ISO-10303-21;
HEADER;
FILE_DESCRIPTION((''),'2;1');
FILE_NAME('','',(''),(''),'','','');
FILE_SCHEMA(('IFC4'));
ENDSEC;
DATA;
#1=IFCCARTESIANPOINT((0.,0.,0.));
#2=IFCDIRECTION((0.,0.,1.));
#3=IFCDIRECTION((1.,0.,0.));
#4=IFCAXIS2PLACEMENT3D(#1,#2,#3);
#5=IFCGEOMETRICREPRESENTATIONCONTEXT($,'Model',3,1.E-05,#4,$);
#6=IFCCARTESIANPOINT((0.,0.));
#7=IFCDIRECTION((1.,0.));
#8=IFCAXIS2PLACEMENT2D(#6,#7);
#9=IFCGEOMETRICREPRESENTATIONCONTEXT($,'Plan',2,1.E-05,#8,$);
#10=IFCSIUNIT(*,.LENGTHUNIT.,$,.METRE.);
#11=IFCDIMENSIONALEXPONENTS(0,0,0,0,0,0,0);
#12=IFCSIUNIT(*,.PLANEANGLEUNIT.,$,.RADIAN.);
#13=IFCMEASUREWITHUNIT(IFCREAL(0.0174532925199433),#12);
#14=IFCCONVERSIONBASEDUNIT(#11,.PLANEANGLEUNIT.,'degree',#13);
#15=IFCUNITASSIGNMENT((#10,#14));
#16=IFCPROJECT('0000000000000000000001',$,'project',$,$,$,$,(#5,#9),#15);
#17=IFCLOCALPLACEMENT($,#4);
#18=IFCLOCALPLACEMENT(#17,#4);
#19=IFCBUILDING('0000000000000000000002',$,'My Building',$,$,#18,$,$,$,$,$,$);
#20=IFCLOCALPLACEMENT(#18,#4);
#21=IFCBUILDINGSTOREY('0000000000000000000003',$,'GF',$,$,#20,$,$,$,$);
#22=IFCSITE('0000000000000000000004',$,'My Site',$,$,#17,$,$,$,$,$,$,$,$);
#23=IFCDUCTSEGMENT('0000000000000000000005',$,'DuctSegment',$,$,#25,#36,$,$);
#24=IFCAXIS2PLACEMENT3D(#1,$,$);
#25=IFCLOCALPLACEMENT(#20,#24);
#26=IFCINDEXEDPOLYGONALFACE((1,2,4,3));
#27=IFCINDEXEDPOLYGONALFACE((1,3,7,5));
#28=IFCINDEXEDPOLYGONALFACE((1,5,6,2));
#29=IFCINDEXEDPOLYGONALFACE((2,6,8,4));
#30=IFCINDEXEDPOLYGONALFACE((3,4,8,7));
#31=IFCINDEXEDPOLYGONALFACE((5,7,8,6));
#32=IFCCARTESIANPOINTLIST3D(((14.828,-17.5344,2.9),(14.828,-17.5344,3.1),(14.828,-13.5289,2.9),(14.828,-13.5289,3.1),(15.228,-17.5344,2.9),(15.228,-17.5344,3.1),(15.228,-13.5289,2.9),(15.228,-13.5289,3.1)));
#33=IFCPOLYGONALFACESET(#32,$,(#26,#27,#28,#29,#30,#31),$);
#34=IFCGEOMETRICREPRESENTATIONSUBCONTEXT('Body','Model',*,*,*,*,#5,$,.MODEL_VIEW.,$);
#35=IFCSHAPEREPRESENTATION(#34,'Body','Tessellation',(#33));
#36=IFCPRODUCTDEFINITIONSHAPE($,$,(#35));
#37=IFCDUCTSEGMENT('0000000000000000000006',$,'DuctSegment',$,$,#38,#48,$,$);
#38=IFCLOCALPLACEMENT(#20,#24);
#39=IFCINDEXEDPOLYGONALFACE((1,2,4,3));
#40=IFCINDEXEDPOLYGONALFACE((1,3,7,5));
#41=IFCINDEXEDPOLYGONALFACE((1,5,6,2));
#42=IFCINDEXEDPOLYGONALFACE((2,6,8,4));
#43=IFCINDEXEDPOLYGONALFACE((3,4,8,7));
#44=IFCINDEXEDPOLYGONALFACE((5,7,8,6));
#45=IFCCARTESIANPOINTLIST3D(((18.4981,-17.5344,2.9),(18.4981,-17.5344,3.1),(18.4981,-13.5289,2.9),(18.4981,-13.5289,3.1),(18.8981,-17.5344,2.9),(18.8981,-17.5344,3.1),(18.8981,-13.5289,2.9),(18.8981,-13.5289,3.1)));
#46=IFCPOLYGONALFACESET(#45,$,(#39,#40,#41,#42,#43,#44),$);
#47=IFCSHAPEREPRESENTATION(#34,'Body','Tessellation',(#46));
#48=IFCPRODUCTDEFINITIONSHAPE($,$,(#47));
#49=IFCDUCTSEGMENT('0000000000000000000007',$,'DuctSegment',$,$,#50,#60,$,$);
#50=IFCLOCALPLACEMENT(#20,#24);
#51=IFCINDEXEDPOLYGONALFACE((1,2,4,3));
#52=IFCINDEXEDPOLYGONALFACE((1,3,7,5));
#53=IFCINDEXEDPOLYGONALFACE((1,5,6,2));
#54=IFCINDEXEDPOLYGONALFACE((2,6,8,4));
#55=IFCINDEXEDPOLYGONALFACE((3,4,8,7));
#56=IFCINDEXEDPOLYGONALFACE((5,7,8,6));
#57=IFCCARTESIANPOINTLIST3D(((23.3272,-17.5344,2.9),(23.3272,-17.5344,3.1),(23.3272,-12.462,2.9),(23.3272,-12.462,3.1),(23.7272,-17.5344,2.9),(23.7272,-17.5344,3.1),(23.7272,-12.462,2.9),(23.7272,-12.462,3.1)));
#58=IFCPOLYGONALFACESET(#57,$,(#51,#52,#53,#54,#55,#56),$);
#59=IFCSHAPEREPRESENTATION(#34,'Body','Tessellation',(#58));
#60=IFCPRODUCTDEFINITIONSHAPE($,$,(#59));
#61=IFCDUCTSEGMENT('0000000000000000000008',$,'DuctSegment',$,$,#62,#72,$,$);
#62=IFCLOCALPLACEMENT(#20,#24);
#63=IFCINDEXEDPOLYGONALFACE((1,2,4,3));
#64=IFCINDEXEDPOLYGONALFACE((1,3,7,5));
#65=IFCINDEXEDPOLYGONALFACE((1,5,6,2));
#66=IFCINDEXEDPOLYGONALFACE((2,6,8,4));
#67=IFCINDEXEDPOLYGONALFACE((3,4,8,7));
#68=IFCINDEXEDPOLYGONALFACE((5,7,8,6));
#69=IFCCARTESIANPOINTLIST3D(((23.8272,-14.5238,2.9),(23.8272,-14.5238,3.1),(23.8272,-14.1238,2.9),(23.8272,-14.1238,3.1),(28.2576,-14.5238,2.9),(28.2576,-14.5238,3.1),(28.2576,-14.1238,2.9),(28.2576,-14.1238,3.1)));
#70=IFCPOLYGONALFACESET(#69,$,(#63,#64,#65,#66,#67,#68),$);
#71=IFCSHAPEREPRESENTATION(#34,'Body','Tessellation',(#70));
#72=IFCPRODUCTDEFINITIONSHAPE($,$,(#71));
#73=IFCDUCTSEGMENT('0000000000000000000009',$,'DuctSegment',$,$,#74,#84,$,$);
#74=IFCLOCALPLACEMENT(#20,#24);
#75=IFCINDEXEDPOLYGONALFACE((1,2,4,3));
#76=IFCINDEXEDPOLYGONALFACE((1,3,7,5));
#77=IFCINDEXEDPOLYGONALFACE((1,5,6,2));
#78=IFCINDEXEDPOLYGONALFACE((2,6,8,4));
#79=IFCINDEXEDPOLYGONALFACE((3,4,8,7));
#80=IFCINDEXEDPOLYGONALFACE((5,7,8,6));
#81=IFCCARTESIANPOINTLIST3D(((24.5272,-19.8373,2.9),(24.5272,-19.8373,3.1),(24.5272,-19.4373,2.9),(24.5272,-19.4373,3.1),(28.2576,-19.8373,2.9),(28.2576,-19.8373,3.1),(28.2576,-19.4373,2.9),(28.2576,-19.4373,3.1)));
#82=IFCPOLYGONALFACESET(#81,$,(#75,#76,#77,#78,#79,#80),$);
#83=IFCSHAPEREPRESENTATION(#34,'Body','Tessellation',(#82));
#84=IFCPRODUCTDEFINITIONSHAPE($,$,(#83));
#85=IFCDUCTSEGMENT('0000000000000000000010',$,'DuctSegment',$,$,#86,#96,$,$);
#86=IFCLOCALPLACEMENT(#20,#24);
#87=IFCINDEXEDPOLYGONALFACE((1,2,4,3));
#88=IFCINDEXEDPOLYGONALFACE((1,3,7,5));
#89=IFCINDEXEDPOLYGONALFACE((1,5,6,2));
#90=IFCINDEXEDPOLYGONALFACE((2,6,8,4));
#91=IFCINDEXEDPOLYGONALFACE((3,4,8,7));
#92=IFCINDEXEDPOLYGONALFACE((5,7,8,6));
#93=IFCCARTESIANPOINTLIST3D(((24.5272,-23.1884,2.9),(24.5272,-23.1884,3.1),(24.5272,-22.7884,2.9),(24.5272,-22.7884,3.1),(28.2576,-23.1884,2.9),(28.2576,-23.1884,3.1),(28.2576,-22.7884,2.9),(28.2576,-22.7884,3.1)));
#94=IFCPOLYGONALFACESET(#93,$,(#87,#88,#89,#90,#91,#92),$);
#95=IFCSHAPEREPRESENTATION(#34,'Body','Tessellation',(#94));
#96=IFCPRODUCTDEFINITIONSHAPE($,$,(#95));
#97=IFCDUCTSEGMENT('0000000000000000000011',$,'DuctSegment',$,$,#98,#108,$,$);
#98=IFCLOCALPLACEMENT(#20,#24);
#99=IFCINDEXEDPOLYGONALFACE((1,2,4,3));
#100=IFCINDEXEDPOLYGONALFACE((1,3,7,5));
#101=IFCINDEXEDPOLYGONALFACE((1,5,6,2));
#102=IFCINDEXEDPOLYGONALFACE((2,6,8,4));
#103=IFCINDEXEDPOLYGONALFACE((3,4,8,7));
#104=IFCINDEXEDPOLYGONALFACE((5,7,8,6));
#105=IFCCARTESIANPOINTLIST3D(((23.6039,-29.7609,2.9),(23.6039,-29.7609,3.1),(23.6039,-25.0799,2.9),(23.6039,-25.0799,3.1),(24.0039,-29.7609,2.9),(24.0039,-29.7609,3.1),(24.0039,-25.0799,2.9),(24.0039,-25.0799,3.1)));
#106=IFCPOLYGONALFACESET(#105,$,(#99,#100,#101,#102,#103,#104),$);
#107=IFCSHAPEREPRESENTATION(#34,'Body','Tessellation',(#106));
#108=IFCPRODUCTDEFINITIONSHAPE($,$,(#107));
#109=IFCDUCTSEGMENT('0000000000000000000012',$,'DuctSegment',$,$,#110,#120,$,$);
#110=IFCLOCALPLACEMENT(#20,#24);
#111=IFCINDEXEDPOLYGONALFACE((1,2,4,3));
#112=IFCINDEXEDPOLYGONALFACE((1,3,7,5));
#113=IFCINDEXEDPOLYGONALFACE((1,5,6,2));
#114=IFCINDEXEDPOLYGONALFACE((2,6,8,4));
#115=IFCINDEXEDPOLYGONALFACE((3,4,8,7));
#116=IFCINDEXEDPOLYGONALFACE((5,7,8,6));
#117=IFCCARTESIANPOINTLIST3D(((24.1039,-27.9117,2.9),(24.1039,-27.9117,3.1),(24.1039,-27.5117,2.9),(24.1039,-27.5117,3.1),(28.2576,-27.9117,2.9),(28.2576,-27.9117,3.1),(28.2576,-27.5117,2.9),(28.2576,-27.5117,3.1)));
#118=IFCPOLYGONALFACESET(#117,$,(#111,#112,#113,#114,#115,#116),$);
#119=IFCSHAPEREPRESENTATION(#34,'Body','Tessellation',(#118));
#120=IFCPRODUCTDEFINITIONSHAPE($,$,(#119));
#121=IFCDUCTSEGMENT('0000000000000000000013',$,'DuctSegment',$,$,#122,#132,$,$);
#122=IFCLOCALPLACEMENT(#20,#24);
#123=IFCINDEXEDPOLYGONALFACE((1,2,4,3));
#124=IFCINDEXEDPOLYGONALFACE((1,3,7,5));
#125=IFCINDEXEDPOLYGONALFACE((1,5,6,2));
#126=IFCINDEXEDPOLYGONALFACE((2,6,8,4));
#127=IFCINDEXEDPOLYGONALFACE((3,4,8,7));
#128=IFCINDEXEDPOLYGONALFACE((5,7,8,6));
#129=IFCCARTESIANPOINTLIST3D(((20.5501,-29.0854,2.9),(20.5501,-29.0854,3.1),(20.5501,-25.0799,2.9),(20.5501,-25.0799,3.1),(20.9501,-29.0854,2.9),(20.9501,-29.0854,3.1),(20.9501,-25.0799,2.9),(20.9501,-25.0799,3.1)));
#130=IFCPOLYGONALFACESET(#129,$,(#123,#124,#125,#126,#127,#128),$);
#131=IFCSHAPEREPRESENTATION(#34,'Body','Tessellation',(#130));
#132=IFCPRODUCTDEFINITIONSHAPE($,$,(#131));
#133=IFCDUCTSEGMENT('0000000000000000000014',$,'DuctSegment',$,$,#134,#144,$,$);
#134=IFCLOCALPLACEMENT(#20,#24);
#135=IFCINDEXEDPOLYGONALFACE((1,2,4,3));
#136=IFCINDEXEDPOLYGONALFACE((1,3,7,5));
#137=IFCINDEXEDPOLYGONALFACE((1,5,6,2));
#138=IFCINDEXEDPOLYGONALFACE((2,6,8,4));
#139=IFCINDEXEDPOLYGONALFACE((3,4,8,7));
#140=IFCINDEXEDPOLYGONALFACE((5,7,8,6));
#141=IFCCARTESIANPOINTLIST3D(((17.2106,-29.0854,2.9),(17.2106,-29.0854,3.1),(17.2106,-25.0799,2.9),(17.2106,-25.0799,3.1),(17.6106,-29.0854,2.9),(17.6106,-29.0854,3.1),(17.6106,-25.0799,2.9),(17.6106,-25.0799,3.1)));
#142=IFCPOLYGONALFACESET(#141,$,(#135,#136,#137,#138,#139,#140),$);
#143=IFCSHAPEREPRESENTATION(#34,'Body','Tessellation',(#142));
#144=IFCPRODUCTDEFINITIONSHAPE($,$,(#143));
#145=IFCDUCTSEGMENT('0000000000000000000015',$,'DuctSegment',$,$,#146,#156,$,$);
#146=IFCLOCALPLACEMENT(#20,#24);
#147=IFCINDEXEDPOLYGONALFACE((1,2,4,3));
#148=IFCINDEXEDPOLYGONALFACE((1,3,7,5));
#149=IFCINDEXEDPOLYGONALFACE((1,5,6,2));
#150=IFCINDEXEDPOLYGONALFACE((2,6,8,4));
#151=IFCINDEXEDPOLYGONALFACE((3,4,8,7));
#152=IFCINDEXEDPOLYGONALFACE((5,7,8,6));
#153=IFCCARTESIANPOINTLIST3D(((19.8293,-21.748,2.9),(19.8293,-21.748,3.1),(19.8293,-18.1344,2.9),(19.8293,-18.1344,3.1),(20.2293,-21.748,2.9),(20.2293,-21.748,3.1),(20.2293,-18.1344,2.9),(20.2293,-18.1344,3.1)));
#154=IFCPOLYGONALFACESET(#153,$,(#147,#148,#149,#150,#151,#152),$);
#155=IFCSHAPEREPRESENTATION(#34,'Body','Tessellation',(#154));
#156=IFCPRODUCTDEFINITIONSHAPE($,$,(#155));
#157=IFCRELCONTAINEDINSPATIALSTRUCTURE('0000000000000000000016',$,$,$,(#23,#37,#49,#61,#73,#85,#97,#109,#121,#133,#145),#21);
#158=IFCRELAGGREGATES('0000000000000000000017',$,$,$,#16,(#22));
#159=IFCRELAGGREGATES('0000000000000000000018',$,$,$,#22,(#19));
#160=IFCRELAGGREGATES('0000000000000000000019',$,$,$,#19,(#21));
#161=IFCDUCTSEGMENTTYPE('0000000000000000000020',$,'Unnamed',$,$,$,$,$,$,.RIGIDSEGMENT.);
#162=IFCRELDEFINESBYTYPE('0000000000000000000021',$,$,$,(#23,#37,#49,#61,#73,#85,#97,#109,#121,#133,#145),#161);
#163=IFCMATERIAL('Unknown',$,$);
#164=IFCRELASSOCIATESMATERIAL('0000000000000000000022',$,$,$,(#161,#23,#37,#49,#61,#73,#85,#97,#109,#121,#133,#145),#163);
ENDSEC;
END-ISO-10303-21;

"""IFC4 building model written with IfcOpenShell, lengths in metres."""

from ifc_helpers import new_model, entity, si_unit, converted_unit, frame, origin_with_axes, origin_2d_with_axis, place, context, subcontext, project, spatial, rectangle, extrude, material, material_profile, profile_set, profile_usage, type_object, element, save


model = new_model("IFC4")

# Units and contexts
model_context = context("Model", 3, precision=1e-05, world=origin_with_axes())
plan_context = context("Plan", 2, precision=1e-05, world=origin_2d_with_axis())
body_context_1 = subcontext(model_context, "Body", "Model", "MODEL_VIEW")
ifc_project = project(units=[si_unit("LENGTHUNIT", "METRE"), converted_unit("PLANEANGLEUNIT", "degree", entity("IfcReal", 0.0174532925199433), si_unit("PLANEANGLEUNIT", "RADIAN"), dimensions=[0, 0, 0, 0, 0, 0, 0])], contexts=[model_context, plan_context])

# Site, building, storey
site_placement = place(None, origin_with_axes())
site = spatial("IfcSite", under=ifc_project, at=site_placement, Name="My Site")
building_placement = place(site_placement, origin_with_axes())
building = spatial("IfcBuilding", under=site, at=building_placement, Name="My Building")
storey_placement = place(building_placement, origin_with_axes())
storey = spatial("IfcBuildingStorey", under=building, at=storey_placement, Name="GF")

# Shared definitions
ifc_material = material(Name="Unknown")

# Duct segments
ifc_material_profile_1 = material_profile(ifc_material, rectangle(XDim=0.4, YDim=0.2))
ifc_profile_set_1 = profile_set([ifc_material_profile_1])
duct_segment_type = type_object("IfcDuctSegmentType", Name="Unnamed", PredefinedType="RIGIDSEGMENT", material=ifc_profile_set_1)
ifc_profile_usage_1 = profile_usage(ifc_profile_set_1, cardinal=5)
duct_segment_1_placement = place(storey_placement, frame((15.028, -17.5344, 3.0), z_axis=(0.0, 1.0, 0.0), x_axis=(-1.0, 0.0, 0.0)))
element("IfcDuctSegment", 1, at=duct_segment_1_placement, inside=storey, type_object=duct_segment_type, material=ifc_profile_usage_1, Name="DuctSegment", context=body_context_1, shape_type="SweptSolid", body=[
    extrude(rectangle(XDim=0.4, YDim=0.2), origin_with_axes(), (0.0, 0.0, 1.0), 4.0055),
])
ifc_profile_usage_2 = profile_usage(ifc_profile_set_1, cardinal=5)
duct_segment_2_placement = place(storey_placement, frame((18.6981, -17.5344, 3.0), z_axis=(0.0, 1.0, 0.0), x_axis=(-1.0, 0.0, 0.0)))
element("IfcDuctSegment", 2, at=duct_segment_2_placement, inside=storey, type_object=duct_segment_type, material=ifc_profile_usage_2, Name="DuctSegment", context=body_context_1, shape_type="SweptSolid", body=[
    extrude(rectangle(XDim=0.4, YDim=0.2), origin_with_axes(), (0.0, 0.0, 1.0), 4.0055),
])
ifc_profile_usage_3 = profile_usage(ifc_profile_set_1, cardinal=5)
duct_segment_3_placement = place(storey_placement, frame((23.5272, -17.5344, 3.0), z_axis=(0.0, 1.0, 0.0), x_axis=(-1.0, 0.0, 0.0)))
element("IfcDuctSegment", 3, at=duct_segment_3_placement, inside=storey, type_object=duct_segment_type, material=ifc_profile_usage_3, Name="DuctSegment", context=body_context_1, shape_type="SweptSolid", body=[
    extrude(rectangle(XDim=0.4, YDim=0.2), origin_with_axes(), (0.0, 0.0, 1.0), 5.0724),
])
ifc_profile_usage_4 = profile_usage(ifc_profile_set_1, cardinal=5)
duct_segment_4_placement = place(storey_placement, frame((23.8272, -14.3238, 3.0), z_axis=(1.0, 0.0, 0.0), x_axis=(0.0, 1.0, 0.0)))
element("IfcDuctSegment", 4, at=duct_segment_4_placement, inside=storey, type_object=duct_segment_type, material=ifc_profile_usage_4, Name="DuctSegment", context=body_context_1, shape_type="SweptSolid", body=[
    extrude(rectangle(XDim=0.4, YDim=0.2), origin_with_axes(), (0.0, 0.0, 1.0), 4.4304),
])
ifc_profile_usage_5 = profile_usage(ifc_profile_set_1, cardinal=5)
duct_segment_5_placement = place(storey_placement, frame((24.5272, -19.6373, 3.0), z_axis=(1.0, 0.0, 0.0), x_axis=(0.0, 1.0, 0.0)))
element("IfcDuctSegment", 5, at=duct_segment_5_placement, inside=storey, type_object=duct_segment_type, material=ifc_profile_usage_5, Name="DuctSegment", context=body_context_1, shape_type="SweptSolid", body=[
    extrude(rectangle(XDim=0.4, YDim=0.2), origin_with_axes(), (0.0, 0.0, 1.0), 3.7304),
])
ifc_profile_usage_6 = profile_usage(ifc_profile_set_1, cardinal=5)
duct_segment_6_placement = place(storey_placement, frame((24.5272, -22.9884, 3.0), z_axis=(1.0, 0.0, 0.0), x_axis=(0.0, 1.0, 0.0)))
element("IfcDuctSegment", 6, at=duct_segment_6_placement, inside=storey, type_object=duct_segment_type, material=ifc_profile_usage_6, Name="DuctSegment", context=body_context_1, shape_type="SweptSolid", body=[
    extrude(rectangle(XDim=0.4, YDim=0.2), origin_with_axes(), (0.0, 0.0, 1.0), 3.7304),
])
ifc_profile_usage_7 = profile_usage(ifc_profile_set_1, cardinal=5)
duct_segment_7_placement = place(storey_placement, frame((23.8039, -25.0799, 3.0), z_axis=(0.0, -1.0, 0.0), x_axis=(1.0, 0.0, 0.0)))
element("IfcDuctSegment", 7, at=duct_segment_7_placement, inside=storey, type_object=duct_segment_type, material=ifc_profile_usage_7, Name="DuctSegment", context=body_context_1, shape_type="SweptSolid", body=[
    extrude(rectangle(XDim=0.4, YDim=0.2), origin_with_axes(), (0.0, 0.0, 1.0), 4.681),
])
ifc_profile_usage_8 = profile_usage(ifc_profile_set_1, cardinal=5)
duct_segment_8_placement = place(storey_placement, frame((24.1039, -27.7117, 3.0), z_axis=(1.0, 0.0, 0.0), x_axis=(0.0, 1.0, 0.0)))
element("IfcDuctSegment", 8, at=duct_segment_8_placement, inside=storey, type_object=duct_segment_type, material=ifc_profile_usage_8, Name="DuctSegment", context=body_context_1, shape_type="SweptSolid", body=[
    extrude(rectangle(XDim=0.4, YDim=0.2), origin_with_axes(), (0.0, 0.0, 1.0), 4.1537),
])
ifc_profile_usage_9 = profile_usage(ifc_profile_set_1, cardinal=5)
duct_segment_9_placement = place(storey_placement, frame((20.7501, -25.0799, 3.0), z_axis=(0.0, -1.0, 0.0), x_axis=(1.0, 0.0, 0.0)))
element("IfcDuctSegment", 9, at=duct_segment_9_placement, inside=storey, type_object=duct_segment_type, material=ifc_profile_usage_9, Name="DuctSegment", context=body_context_1, shape_type="SweptSolid", body=[
    extrude(rectangle(XDim=0.4, YDim=0.2), origin_with_axes(), (0.0, 0.0, 1.0), 4.0055),
])
ifc_profile_usage_10 = profile_usage(ifc_profile_set_1, cardinal=5)
duct_segment_10_placement = place(storey_placement, frame((17.4106, -25.0799, 3.0), z_axis=(0.0, -1.0, 0.0), x_axis=(1.0, 0.0, 0.0)))
element("IfcDuctSegment", 10, at=duct_segment_10_placement, inside=storey, type_object=duct_segment_type, material=ifc_profile_usage_10, Name="DuctSegment", context=body_context_1, shape_type="SweptSolid", body=[
    extrude(rectangle(XDim=0.4, YDim=0.2), origin_with_axes(), (0.0, 0.0, 1.0), 4.0055),
])
ifc_profile_usage_11 = profile_usage(ifc_profile_set_1, cardinal=5)
duct_segment_11_placement = place(storey_placement, frame((20.0293, -18.1344, 3.0), z_axis=(0.0, -1.0, 0.0), x_axis=(1.0, 0.0, 0.0)))
element("IfcDuctSegment", 11, at=duct_segment_11_placement, inside=storey, type_object=duct_segment_type, material=ifc_profile_usage_11, Name="DuctSegment", context=body_context_1, shape_type="SweptSolid", body=[
    extrude(rectangle(XDim=0.4, YDim=0.2), origin_with_axes(), (0.0, 0.0, 1.0), 3.6136),
])

save(model, "model.ifc")
